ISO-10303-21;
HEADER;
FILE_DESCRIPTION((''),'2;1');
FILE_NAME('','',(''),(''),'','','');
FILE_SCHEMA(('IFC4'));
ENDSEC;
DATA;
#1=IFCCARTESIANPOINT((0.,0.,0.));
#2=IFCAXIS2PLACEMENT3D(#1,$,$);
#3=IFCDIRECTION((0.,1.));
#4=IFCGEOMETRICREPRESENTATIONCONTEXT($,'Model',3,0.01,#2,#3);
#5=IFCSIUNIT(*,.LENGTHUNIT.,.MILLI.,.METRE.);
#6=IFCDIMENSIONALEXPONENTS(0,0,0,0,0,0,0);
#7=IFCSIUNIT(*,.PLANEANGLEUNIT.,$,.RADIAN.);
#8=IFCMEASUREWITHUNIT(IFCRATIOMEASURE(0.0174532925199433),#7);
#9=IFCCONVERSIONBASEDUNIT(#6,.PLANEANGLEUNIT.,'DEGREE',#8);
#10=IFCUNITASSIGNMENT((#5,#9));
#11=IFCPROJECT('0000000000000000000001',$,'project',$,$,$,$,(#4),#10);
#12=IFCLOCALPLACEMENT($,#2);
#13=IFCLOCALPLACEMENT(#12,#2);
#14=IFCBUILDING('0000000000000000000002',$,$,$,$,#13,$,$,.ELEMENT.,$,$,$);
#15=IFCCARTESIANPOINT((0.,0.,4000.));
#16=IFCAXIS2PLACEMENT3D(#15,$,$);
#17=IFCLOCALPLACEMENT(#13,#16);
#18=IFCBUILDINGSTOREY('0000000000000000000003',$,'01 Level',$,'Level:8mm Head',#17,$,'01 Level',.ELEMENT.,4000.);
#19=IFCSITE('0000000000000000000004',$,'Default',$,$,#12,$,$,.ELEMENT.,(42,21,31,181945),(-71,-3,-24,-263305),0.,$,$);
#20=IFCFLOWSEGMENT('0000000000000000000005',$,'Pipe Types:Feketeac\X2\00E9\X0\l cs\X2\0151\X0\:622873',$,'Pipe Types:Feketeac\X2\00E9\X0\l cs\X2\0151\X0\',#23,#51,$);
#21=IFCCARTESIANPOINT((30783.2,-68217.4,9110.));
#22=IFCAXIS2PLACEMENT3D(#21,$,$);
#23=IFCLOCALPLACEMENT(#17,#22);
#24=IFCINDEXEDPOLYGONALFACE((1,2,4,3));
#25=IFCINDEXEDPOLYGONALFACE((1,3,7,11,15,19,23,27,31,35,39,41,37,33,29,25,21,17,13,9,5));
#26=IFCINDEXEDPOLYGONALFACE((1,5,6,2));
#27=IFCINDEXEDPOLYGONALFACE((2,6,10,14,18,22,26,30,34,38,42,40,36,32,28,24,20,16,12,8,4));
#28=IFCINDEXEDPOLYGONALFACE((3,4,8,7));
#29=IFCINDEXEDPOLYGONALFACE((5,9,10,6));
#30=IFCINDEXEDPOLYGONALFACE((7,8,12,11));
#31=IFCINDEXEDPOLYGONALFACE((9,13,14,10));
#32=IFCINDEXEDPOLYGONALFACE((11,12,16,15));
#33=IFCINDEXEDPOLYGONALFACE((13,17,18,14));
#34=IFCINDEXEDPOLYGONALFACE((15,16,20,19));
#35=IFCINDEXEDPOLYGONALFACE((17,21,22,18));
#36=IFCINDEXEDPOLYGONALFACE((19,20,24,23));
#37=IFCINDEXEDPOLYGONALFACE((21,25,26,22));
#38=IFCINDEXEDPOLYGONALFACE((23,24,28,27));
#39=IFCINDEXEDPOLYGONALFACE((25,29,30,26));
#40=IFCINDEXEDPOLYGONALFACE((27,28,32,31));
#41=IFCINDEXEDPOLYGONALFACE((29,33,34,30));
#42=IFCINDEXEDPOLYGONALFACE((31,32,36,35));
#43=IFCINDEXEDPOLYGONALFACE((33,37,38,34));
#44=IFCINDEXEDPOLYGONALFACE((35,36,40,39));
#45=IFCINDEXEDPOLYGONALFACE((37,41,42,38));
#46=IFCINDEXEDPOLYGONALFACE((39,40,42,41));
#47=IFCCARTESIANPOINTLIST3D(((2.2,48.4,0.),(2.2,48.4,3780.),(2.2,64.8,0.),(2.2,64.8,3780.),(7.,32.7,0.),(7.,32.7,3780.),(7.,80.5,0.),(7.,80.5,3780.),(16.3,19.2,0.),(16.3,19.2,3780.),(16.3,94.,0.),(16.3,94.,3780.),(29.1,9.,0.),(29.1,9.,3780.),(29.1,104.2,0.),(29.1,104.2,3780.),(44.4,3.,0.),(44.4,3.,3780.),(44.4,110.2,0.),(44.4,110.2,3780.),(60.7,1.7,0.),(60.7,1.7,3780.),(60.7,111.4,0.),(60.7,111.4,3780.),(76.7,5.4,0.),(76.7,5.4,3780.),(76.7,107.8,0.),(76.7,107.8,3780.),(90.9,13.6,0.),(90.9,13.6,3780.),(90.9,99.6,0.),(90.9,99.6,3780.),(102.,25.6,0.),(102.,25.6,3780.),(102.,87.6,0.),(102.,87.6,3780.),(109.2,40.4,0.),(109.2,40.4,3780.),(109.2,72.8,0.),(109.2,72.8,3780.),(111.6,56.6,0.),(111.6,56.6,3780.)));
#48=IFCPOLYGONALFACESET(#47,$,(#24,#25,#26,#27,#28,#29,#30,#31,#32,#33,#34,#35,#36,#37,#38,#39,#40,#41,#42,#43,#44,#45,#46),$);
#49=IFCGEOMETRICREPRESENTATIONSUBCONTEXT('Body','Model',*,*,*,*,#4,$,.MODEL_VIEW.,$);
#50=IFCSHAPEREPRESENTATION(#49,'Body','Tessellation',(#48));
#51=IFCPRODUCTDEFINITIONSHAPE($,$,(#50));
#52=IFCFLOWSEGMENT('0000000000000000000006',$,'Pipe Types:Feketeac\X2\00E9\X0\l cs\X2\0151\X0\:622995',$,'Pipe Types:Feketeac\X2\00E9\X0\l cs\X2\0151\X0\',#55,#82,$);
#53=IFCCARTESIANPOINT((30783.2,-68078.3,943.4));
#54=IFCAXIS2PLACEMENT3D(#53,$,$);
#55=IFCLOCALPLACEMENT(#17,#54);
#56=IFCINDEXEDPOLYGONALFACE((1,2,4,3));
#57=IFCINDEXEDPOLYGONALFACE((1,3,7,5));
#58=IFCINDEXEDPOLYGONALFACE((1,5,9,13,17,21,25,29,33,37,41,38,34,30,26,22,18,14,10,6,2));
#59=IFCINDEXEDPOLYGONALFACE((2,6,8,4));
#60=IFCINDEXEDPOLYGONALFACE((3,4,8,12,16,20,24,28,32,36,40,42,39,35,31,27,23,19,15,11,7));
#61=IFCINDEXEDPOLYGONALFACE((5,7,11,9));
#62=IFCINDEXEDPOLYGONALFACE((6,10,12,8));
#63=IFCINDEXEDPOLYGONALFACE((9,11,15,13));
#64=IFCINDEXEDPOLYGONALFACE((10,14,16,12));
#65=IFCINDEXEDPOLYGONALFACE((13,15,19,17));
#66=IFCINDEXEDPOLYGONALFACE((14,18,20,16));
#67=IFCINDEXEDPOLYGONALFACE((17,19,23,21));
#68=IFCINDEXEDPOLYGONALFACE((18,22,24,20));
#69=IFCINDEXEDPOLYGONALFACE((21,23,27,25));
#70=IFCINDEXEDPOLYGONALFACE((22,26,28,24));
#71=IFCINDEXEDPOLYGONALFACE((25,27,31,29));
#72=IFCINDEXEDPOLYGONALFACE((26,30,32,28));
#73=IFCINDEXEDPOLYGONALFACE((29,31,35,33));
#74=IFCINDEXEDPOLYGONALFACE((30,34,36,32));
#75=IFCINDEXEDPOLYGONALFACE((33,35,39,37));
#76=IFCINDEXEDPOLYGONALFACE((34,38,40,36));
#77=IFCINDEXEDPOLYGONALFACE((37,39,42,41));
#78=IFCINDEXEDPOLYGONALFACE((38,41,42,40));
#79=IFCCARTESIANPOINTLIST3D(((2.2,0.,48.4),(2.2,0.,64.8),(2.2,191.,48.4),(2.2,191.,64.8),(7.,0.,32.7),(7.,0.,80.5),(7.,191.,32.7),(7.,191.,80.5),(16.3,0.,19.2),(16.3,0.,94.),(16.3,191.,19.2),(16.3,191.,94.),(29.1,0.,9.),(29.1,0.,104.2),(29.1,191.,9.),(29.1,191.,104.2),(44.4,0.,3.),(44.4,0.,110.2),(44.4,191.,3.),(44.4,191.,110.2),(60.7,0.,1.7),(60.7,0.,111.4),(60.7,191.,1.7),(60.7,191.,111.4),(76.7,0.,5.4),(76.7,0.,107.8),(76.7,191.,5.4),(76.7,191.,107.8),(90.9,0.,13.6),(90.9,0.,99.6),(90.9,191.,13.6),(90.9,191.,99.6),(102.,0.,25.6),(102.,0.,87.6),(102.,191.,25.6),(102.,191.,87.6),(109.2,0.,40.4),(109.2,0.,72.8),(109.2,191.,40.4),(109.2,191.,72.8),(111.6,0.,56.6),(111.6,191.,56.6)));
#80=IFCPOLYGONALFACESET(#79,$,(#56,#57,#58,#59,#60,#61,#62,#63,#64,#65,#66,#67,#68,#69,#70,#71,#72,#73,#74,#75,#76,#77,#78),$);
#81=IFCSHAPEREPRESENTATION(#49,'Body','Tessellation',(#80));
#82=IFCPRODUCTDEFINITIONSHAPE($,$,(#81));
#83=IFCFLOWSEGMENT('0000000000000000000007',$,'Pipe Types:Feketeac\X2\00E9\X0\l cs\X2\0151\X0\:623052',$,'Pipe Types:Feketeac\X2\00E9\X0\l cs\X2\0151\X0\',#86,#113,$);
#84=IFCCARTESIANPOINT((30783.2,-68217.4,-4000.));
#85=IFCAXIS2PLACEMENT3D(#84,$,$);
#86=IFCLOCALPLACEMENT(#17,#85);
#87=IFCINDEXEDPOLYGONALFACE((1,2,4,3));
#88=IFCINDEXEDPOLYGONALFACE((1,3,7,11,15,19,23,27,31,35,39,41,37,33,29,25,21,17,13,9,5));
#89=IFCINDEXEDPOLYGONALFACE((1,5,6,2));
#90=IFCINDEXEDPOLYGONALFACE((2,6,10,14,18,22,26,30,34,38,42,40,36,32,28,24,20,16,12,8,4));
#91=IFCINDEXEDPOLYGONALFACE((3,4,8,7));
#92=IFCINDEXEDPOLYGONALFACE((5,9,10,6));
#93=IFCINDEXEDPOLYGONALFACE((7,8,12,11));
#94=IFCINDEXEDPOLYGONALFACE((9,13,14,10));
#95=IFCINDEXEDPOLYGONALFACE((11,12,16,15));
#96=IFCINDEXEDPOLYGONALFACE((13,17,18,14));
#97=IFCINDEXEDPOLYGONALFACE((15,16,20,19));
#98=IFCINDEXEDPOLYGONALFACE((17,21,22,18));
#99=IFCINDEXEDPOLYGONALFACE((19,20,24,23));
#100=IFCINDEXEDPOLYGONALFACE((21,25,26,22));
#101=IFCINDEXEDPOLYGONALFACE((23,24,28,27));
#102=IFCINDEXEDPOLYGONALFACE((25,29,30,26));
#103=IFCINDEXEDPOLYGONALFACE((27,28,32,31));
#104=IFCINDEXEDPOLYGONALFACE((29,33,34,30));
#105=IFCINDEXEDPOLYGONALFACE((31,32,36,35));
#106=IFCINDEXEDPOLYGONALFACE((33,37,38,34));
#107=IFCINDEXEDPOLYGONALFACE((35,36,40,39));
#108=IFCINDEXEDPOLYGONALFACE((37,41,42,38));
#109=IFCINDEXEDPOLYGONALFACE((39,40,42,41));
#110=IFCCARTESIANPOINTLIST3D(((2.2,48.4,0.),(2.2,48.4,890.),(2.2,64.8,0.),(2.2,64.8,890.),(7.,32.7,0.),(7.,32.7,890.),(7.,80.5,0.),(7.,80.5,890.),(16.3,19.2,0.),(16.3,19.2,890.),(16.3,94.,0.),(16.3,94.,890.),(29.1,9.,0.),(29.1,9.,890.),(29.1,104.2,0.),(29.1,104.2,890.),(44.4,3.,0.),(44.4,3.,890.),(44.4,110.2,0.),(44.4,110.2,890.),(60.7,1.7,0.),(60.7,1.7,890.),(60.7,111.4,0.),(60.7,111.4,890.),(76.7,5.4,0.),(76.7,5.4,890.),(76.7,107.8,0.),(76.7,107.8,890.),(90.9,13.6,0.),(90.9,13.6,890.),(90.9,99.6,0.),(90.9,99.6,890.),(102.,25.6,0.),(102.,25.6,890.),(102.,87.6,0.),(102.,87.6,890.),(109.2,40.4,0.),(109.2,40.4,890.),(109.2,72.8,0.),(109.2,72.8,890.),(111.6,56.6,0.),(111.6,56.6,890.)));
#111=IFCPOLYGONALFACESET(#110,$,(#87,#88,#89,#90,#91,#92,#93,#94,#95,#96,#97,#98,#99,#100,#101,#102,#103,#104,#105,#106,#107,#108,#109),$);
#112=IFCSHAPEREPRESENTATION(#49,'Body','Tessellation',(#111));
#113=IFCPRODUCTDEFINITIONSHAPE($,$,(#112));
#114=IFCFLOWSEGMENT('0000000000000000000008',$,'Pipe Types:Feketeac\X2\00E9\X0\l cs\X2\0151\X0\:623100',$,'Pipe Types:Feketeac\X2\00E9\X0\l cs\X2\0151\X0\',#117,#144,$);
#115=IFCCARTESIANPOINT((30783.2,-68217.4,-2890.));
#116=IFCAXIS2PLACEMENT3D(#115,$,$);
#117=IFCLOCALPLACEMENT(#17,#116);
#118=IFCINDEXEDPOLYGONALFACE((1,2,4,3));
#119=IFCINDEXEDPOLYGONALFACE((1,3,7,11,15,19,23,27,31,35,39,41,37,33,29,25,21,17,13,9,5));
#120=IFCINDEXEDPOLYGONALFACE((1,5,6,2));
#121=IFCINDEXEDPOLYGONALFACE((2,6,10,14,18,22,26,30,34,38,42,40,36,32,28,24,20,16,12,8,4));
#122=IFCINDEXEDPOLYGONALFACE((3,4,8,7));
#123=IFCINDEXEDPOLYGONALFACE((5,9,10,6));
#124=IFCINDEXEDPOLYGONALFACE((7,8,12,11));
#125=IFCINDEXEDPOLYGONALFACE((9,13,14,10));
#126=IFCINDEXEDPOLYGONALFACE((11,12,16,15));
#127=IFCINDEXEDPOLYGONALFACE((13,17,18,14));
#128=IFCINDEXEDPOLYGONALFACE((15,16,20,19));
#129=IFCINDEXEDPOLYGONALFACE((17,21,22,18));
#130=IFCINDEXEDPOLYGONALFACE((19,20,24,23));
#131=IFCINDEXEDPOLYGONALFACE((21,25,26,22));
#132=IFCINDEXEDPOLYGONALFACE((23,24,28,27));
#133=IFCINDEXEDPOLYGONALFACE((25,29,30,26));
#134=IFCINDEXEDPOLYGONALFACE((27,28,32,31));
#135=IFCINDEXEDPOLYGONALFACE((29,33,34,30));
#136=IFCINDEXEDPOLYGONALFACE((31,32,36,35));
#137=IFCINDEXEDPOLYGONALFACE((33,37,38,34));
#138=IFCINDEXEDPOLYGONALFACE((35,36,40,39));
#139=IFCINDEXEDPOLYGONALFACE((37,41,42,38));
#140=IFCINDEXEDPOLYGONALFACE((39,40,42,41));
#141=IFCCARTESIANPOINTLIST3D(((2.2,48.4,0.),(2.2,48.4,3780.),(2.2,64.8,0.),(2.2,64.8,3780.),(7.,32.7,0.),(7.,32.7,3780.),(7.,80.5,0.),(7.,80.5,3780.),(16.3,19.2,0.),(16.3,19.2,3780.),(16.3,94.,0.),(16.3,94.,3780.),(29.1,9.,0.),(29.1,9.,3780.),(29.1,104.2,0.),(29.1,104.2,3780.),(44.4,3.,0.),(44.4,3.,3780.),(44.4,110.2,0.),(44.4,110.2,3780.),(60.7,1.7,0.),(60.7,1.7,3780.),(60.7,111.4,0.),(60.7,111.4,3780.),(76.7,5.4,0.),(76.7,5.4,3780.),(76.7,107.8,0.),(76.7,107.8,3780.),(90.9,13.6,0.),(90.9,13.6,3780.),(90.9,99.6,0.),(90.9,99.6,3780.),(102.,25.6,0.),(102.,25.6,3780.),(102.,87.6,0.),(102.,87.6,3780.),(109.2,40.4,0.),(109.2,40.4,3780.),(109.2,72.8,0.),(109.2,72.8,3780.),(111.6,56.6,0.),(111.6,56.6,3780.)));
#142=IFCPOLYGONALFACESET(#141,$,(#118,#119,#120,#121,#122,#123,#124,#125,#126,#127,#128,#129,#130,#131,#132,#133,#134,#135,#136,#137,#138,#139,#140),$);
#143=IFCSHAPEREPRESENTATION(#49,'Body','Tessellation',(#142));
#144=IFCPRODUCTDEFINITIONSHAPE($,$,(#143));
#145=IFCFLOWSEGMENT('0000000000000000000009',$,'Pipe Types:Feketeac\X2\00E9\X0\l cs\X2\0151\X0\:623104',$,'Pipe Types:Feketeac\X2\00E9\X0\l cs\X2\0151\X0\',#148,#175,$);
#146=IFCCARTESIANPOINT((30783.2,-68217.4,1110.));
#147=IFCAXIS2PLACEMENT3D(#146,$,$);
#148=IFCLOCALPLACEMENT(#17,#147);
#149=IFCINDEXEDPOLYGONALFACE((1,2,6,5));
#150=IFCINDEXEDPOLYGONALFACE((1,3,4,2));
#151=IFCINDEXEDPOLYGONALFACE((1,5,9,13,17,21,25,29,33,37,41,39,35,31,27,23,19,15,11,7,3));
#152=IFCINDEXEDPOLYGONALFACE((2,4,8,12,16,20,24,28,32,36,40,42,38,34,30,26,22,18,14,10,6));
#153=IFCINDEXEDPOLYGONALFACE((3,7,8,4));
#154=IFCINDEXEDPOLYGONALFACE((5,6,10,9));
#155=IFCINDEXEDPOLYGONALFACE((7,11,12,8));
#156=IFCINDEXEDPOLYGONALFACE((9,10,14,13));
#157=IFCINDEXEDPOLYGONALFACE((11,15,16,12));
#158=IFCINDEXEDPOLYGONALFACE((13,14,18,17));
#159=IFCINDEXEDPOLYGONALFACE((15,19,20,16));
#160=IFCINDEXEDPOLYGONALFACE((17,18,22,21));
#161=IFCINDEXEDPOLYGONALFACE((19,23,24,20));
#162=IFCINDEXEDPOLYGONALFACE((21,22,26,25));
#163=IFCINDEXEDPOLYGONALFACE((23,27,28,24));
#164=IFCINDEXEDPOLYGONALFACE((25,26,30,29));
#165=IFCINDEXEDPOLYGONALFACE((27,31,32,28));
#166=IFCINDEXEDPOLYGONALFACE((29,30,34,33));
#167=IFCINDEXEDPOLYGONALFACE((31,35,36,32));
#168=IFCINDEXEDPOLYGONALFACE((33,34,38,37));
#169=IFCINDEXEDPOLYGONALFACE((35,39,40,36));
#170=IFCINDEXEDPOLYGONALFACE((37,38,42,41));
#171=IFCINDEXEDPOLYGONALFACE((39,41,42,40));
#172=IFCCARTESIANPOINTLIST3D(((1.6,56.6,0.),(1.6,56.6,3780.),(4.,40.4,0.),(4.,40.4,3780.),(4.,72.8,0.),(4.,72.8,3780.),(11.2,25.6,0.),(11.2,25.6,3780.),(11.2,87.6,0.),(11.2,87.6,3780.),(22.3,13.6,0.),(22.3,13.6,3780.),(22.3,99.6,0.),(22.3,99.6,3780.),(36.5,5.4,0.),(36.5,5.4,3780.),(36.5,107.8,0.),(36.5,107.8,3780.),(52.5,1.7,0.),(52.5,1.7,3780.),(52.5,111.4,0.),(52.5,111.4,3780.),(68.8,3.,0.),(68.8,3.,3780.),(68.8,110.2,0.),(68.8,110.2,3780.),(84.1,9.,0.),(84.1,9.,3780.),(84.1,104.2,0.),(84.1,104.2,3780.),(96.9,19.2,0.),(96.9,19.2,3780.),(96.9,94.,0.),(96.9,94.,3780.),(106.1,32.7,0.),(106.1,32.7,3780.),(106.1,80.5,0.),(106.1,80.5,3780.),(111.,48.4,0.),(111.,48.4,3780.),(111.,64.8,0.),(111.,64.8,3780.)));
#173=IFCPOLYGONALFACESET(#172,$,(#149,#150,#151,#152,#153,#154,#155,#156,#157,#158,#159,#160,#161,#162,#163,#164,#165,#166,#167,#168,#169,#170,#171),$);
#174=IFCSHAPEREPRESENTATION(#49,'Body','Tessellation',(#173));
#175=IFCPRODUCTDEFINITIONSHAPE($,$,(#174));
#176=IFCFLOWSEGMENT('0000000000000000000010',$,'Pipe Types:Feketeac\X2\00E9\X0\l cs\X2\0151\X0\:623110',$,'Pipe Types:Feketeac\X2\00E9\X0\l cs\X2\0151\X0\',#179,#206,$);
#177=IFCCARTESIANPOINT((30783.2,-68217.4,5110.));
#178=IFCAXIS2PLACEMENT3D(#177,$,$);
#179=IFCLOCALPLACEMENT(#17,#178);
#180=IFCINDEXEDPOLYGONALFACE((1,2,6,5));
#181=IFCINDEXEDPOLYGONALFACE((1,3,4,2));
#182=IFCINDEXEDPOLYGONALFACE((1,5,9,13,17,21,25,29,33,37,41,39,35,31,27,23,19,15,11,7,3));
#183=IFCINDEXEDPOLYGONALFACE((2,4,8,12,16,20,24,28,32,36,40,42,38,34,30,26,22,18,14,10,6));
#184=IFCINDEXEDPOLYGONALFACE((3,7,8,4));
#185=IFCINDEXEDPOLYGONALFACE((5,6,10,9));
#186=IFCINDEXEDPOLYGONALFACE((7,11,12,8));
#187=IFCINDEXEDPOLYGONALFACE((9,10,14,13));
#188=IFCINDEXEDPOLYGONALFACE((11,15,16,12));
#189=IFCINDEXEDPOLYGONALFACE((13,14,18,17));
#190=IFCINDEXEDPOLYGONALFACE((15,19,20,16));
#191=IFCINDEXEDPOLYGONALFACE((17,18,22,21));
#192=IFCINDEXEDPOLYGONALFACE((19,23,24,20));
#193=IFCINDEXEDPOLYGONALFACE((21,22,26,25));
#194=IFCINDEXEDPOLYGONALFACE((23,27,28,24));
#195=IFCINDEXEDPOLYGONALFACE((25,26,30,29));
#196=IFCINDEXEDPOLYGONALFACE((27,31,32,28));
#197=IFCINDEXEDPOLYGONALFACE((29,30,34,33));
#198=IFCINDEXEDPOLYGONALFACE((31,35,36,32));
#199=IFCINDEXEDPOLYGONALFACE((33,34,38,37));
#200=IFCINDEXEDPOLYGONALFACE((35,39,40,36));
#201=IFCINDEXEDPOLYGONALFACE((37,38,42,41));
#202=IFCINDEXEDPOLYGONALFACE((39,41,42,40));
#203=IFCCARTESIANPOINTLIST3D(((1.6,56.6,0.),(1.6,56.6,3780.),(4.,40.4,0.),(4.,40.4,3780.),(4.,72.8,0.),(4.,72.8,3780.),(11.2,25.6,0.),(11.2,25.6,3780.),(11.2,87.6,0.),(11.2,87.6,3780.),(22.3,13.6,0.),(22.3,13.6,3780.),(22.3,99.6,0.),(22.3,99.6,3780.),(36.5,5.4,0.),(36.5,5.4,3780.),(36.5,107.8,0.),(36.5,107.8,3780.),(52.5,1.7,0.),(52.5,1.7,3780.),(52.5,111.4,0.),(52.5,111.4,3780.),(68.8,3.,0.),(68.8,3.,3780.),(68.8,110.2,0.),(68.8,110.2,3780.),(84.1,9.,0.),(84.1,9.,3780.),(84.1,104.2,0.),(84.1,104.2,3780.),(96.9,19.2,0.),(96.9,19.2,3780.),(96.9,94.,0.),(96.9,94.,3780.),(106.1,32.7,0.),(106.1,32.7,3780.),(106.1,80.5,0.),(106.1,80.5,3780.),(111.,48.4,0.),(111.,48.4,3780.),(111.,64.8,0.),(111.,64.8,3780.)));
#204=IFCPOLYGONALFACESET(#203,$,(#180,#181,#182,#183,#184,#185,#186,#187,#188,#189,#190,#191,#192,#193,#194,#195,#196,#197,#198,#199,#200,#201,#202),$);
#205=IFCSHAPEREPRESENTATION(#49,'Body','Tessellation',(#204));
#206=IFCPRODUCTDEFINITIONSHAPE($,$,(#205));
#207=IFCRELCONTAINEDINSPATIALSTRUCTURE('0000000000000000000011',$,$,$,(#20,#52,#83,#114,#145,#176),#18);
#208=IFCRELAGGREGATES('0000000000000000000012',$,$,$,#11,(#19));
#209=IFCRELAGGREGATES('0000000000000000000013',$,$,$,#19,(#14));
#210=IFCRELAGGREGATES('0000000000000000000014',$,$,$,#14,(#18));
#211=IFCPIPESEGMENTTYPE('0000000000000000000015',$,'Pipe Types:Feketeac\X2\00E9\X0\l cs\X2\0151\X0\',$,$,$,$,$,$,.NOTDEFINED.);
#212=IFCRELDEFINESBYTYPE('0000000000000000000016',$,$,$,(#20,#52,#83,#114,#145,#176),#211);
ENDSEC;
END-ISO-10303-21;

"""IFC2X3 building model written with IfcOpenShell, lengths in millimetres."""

from ifc_helpers import new_model, entity, si_unit, converted_unit, direction, frame, origin, origin_2d_with_axis, place, context, subcontext, project, spatial, circle, extrude, type_object, element, save


model = new_model("IFC2X3")

# Units and contexts
model_context = context("Model", 3, precision=0.01, world=origin(), true_north=direction((0.0, 1.0)))
body_context = subcontext(model_context, "Body", "Model", "MODEL_VIEW")
ifc_project = project(units=[si_unit("LENGTHUNIT", "METRE", prefix="MILLI"), converted_unit("PLANEANGLEUNIT", "DEGREE", entity("IfcRatioMeasure", 0.0174532925199433), si_unit("PLANEANGLEUNIT", "RADIAN"), dimensions=[0, 0, 0, 0, 0, 0, 0])], contexts=[model_context])

# Site, building, storey
site_placement = place(None, origin())
site = spatial("IfcSite", under=ifc_project, at=site_placement, Name="Default", CompositionType="ELEMENT", RefLatitude=(42, 21, 31, 181945), RefLongitude=(-71, -3, -24, -263305), RefElevation=0.0)
building_placement = place(site_placement, origin())
building = spatial("IfcBuilding", under=site, at=building_placement, CompositionType="ELEMENT")
storey_placement = place(building_placement, frame((0.0, 0.0, 4000.0)))
storey = spatial("IfcBuildingStorey", under=building, at=storey_placement, Name="01 Level", ObjectType="Level:8mm Head", LongName="01 Level", CompositionType="ELEMENT", Elevation=4000.0)

# Flow segments
pipe_segment_type = type_object("IfcPipeSegmentType", Name="Pipe Types:Feketeacél cső", PredefinedType="NOTDEFINED")
flow_segment_1_placement = place(storey_placement, frame((30783.2, -68217.4, 9110.0)))
element("IfcFlowSegment", 1, at=flow_segment_1_placement, inside=storey, type_object=pipe_segment_type, Name="Pipe Types:Feketeacél cső:622873", ObjectType="Pipe Types:Feketeacél cső", context=body_context, shape_type="SweptSolid", body=[
    extrude(circle(Radius=55.0, at=origin_2d_with_axis()), frame((56.6, 56.6, 0.0)), (0.0, 0.0, 1.0), 3780.0),
])
flow_segment_2_placement = place(storey_placement, frame((30783.2, -68078.3, 943.4)))
element("IfcFlowSegment", 2, at=flow_segment_2_placement, inside=storey, type_object=pipe_segment_type, Name="Pipe Types:Feketeacél cső:622995", ObjectType="Pipe Types:Feketeacél cső", context=body_context, shape_type="SweptSolid", body=[
    extrude(circle(Radius=55.0, at=origin_2d_with_axis()), frame((56.6, 0.0, 56.6), z_axis=(0.0, 1.0, 0.0), x_axis=(1.0, 0.0, 0.0)), (0.0, 0.0, 1.0), 191.0),
])
flow_segment_3_placement = place(storey_placement, frame((30783.2, -68217.4, -4000.0)))
element("IfcFlowSegment", 3, at=flow_segment_3_placement, inside=storey, type_object=pipe_segment_type, Name="Pipe Types:Feketeacél cső:623052", ObjectType="Pipe Types:Feketeacél cső", context=body_context, shape_type="SweptSolid", body=[
    extrude(circle(Radius=55.0, at=origin_2d_with_axis()), frame((56.6, 56.6, 0.0)), (0.0, 0.0, 1.0), 890.0),
])
flow_segment_4_placement = place(storey_placement, frame((30783.2, -68217.4, -2890.0)))
element("IfcFlowSegment", 4, at=flow_segment_4_placement, inside=storey, type_object=pipe_segment_type, Name="Pipe Types:Feketeacél cső:623100", ObjectType="Pipe Types:Feketeacél cső", context=body_context, shape_type="SweptSolid", body=[
    extrude(circle(Radius=55.0, at=origin_2d_with_axis()), frame((56.6, 56.6, 0.0)), (0.0, 0.0, 1.0), 3780.0),
])
for number, where, name in (
    (5, (30783.2, -68217.4, 1110.0), "Pipe Types:Feketeacél cső:623104"),
    (6, (30783.2, -68217.4, 5110.0), "Pipe Types:Feketeacél cső:623110"),
):
    element("IfcFlowSegment", number, at=place(storey_placement, frame(where)), inside=storey, type_object=pipe_segment_type, Name=name, ObjectType="Pipe Types:Feketeacél cső", context=body_context, shape_type="SweptSolid", body=[
        extrude(circle(Radius=55.0, at=origin_2d_with_axis()), frame((56.6, 56.6, 0.0), z_axis=(0.0, 0.0, 1.0), x_axis=(-1.0, 0.0, 0.0)), (0.0, 0.0, 1.0), 3780.0),
    ])

save(model, "model.ifc")
